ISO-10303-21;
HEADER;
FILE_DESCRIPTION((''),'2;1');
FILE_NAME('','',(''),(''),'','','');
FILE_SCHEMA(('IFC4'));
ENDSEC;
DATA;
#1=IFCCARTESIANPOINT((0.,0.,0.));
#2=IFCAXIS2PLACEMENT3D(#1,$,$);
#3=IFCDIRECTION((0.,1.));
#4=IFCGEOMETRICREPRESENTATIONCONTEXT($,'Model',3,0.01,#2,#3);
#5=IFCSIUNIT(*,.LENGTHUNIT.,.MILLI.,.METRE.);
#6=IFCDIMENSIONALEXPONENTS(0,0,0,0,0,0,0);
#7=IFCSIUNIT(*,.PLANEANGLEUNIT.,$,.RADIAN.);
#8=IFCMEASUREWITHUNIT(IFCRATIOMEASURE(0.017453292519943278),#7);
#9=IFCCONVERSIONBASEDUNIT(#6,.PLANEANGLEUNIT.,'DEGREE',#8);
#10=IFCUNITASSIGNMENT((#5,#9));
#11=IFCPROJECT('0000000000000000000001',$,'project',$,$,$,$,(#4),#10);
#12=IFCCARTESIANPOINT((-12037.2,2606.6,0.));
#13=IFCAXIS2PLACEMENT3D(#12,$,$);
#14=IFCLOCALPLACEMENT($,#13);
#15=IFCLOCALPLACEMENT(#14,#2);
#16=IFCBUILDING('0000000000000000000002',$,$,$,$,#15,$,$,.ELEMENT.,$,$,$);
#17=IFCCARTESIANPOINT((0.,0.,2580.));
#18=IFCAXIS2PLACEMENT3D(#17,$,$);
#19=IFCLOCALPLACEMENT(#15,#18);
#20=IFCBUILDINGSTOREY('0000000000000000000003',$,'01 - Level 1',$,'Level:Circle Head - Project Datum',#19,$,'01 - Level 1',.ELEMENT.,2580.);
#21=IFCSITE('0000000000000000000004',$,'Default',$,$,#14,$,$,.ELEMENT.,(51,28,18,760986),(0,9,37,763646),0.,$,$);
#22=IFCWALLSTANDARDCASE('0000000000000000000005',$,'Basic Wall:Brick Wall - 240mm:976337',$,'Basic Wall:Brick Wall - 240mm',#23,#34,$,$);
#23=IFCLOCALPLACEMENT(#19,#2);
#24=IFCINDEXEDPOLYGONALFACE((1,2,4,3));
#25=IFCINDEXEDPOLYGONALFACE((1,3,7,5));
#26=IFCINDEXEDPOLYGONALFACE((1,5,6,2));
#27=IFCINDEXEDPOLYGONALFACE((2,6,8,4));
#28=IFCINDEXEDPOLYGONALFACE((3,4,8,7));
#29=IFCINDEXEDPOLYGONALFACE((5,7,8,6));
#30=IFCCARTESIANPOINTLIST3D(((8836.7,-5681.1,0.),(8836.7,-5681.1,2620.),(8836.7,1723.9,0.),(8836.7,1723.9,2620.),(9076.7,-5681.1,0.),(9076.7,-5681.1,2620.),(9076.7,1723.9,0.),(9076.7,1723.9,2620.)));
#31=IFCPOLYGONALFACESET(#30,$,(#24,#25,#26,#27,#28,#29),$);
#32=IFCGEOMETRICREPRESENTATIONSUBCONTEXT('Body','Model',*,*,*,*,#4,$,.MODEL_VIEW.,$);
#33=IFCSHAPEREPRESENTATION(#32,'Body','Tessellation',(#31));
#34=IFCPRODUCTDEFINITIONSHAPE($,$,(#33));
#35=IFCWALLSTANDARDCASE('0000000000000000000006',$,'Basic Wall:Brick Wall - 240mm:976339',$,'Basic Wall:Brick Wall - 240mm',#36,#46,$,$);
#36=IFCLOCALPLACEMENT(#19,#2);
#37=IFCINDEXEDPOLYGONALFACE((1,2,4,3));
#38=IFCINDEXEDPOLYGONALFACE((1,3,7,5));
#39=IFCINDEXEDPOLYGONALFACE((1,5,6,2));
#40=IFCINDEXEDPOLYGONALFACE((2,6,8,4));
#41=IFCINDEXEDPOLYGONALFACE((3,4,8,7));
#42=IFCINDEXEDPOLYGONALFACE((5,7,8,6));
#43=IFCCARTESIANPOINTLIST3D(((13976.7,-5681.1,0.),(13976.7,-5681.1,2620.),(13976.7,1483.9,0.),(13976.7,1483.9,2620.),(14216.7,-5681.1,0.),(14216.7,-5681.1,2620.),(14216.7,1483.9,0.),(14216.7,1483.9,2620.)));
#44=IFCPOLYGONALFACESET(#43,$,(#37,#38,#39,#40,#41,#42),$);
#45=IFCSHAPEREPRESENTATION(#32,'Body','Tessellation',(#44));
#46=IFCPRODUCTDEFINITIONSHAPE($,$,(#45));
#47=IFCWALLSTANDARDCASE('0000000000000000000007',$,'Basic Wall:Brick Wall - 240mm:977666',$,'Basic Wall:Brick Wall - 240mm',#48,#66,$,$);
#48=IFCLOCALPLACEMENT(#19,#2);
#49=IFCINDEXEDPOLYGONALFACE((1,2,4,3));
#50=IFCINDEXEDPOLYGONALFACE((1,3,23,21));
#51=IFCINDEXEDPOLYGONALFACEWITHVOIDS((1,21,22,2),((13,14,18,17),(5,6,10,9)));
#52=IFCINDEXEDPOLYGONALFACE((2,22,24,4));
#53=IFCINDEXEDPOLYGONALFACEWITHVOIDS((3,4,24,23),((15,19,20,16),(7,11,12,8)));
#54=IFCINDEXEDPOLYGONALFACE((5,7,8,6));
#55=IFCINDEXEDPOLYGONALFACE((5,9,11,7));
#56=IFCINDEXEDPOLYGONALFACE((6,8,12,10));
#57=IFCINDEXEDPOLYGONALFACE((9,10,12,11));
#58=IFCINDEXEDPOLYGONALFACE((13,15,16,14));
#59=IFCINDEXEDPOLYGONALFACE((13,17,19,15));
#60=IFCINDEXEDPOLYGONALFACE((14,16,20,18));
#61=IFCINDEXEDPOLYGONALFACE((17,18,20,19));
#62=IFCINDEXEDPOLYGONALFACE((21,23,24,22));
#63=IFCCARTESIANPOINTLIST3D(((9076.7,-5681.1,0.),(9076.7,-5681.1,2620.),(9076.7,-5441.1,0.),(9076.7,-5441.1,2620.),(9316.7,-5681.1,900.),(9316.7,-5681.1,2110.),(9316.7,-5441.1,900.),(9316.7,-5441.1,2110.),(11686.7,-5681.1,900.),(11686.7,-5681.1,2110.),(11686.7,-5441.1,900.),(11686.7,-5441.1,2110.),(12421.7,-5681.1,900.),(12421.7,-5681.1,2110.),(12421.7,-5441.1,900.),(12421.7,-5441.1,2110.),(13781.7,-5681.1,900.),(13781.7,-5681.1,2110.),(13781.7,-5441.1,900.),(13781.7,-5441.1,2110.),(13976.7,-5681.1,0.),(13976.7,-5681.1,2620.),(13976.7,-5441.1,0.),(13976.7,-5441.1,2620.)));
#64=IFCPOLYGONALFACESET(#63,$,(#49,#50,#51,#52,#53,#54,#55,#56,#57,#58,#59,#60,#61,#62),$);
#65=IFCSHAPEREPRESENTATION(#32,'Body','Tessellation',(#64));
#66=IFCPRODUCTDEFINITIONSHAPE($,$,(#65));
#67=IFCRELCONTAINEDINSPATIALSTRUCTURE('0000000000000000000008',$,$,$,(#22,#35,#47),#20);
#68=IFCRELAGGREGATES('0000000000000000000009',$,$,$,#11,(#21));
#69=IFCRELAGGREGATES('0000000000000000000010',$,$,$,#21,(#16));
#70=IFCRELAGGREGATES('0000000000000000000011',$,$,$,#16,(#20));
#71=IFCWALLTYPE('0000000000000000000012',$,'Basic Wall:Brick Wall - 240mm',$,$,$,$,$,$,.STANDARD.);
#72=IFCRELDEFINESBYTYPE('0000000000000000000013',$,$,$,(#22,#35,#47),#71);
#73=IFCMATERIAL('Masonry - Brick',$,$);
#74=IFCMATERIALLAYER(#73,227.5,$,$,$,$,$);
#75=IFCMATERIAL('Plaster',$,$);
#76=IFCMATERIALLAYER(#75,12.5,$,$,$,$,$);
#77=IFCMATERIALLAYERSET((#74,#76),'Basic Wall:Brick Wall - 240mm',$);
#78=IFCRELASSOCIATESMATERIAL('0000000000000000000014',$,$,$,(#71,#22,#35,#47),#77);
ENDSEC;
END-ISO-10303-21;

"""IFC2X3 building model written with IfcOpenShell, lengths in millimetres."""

from ifc_helpers import new_model, entity, si_unit, converted_unit, direction, frame, frame_2d, origin, place, context, subcontext, project, spatial, rectangle, extrude, material, layer, layer_set, layer_usage, type_object, element, save


model = new_model("IFC2X3")

# Units and contexts
model_context = context("Model", 3, precision=0.01, world=origin(), true_north=direction((0.0, 1.0)))
body_context = subcontext(model_context, "Body", "Model", "MODEL_VIEW")
ifc_project = project(units=[si_unit("LENGTHUNIT", "METRE", prefix="MILLI"), converted_unit("PLANEANGLEUNIT", "DEGREE", entity("IfcRatioMeasure", 0.017453292519943278), si_unit("PLANEANGLEUNIT", "RADIAN"), dimensions=[0, 0, 0, 0, 0, 0, 0])], contexts=[model_context])

# Site, building, storey
site_placement = place(None, frame((-12037.2, 2606.6, 0.0)))
site = spatial("IfcSite", under=ifc_project, at=site_placement, Name="Default", CompositionType="ELEMENT", RefLatitude=(51, 28, 18, 760986), RefLongitude=(0, 9, 37, 763646), RefElevation=0.0)
building_placement = place(site_placement, origin())
building = spatial("IfcBuilding", under=site, at=building_placement, CompositionType="ELEMENT")
storey_placement = place(building_placement, frame((0.0, 0.0, 2580.0)))
storey = spatial("IfcBuildingStorey", under=building, at=storey_placement, Name="01 - Level 1", ObjectType="Level:Circle Head - Project Datum", LongName="01 - Level 1", CompositionType="ELEMENT", Elevation=2580.0)

# Shared definitions
ifc_material_1 = material(Name="Masonry - Brick")
ifc_material_2 = material(Name="Plaster")

# Walls
ifc_layer_1 = layer(ifc_material_1, 227.5)
ifc_layer_2 = layer(ifc_material_2, 12.5)
ifc_layer_set_1 = layer_set([ifc_layer_1, ifc_layer_2], Name="Basic Wall:Brick Wall - 240mm")
ifc_layer_usage_1 = layer_usage(ifc_layer_set_1, "AXIS2", "NEGATIVE", 120.0)
wall_type_1 = type_object("IfcWallType", Name="Basic Wall:Brick Wall - 240mm", PredefinedType="STANDARD", material=ifc_layer_set_1)
wall_1_placement = place(storey_placement, frame((8956.7, -5681.1, 0.0), z_axis=(0.0, 0.0, 1.0), x_axis=(0.0, 1.0, 0.0)))
element("IfcWallStandardCase", 1, at=wall_1_placement, inside=storey, type_object=wall_type_1, material=ifc_layer_usage_1, Name="Basic Wall:Brick Wall - 240mm:976337", ObjectType="Basic Wall:Brick Wall - 240mm", context=body_context, shape_type="SweptSolid", body=[
    extrude(rectangle(XDim=7405.0, YDim=240.0, at=frame_2d((3702.5, 0.0), x_axis=(-1.0, 0.0))), origin(), (0.0, 0.0, 1.0), 2620.0),
])
ifc_layer_usage_2 = layer_usage(ifc_layer_set_1, "AXIS2", "NEGATIVE", 120.0)
wall_2_placement = place(storey_placement, frame((14096.7, 1483.9, 0.0), z_axis=(0.0, 0.0, 1.0), x_axis=(0.0, -1.0, 0.0)))
element("IfcWallStandardCase", 2, at=wall_2_placement, inside=storey, type_object=wall_type_1, material=ifc_layer_usage_2, Name="Basic Wall:Brick Wall - 240mm:976339", ObjectType="Basic Wall:Brick Wall - 240mm", context=body_context, shape_type="SweptSolid", body=[
    extrude(rectangle(XDim=7165.0, YDim=240.0, at=frame_2d((3582.5, 0.0), x_axis=(-1.0, 0.0))), origin(), (0.0, 0.0, 1.0), 2620.0),
])

# Wall, openings
ifc_layer_usage_3 = layer_usage(ifc_layer_set_1, "AXIS2", "POSITIVE", -120.0)
wall_3_placement = place(storey_placement, frame((9076.7, -5561.1, 0.0)))
wall_3 = element("IfcWallStandardCase", 3, at=wall_3_placement, inside=storey, type_object=wall_type_1, material=ifc_layer_usage_3, Name="Basic Wall:Brick Wall - 240mm:977666", ObjectType="Basic Wall:Brick Wall - 240mm", context=body_context, shape_type="SweptSolid", body=[
    extrude(rectangle(XDim=4900.0, YDim=240.0, at=frame_2d((2450.0, 0.0), x_axis=(-1.0, 0.0))), origin(), (0.0, 0.0, 1.0), 2620.0),
])
opening_1_placement = place(wall_3_placement, frame((2610.0, 120.0, 900.0)))
element("IfcOpeningElement", 4, at=opening_1_placement, cuts=wall_3, ObjectType="Opening", context=body_context, shape_type="SweptSolid", body=[
    extrude(rectangle(XDim=1210.0, YDim=2370.0, at=frame_2d((605.0, 1185.0), x_axis=(-1.0, 0.0))), frame((0.0, 0.0, 0.0), z_axis=(0.0, -1.0, 0.0), x_axis=(0.0, 0.0, 1.0)), (0.0, 0.0, 1.0), 240.0),
])
opening_2_placement = place(wall_3_placement, frame((4705.0, 120.0, 900.0)))
element("IfcOpeningElement", 5, at=opening_2_placement, cuts=wall_3, ObjectType="Opening", context=body_context, shape_type="SweptSolid", body=[
    extrude(rectangle(XDim=1210.0, YDim=1360.0, at=frame_2d((605.0, 680.0), x_axis=(-1.0, 0.0))), frame((0.0, 0.0, 0.0), z_axis=(0.0, -1.0, 0.0), x_axis=(0.0, 0.0, 1.0)), (0.0, 0.0, 1.0), 240.0),
])

save(model, "model.ifc")
